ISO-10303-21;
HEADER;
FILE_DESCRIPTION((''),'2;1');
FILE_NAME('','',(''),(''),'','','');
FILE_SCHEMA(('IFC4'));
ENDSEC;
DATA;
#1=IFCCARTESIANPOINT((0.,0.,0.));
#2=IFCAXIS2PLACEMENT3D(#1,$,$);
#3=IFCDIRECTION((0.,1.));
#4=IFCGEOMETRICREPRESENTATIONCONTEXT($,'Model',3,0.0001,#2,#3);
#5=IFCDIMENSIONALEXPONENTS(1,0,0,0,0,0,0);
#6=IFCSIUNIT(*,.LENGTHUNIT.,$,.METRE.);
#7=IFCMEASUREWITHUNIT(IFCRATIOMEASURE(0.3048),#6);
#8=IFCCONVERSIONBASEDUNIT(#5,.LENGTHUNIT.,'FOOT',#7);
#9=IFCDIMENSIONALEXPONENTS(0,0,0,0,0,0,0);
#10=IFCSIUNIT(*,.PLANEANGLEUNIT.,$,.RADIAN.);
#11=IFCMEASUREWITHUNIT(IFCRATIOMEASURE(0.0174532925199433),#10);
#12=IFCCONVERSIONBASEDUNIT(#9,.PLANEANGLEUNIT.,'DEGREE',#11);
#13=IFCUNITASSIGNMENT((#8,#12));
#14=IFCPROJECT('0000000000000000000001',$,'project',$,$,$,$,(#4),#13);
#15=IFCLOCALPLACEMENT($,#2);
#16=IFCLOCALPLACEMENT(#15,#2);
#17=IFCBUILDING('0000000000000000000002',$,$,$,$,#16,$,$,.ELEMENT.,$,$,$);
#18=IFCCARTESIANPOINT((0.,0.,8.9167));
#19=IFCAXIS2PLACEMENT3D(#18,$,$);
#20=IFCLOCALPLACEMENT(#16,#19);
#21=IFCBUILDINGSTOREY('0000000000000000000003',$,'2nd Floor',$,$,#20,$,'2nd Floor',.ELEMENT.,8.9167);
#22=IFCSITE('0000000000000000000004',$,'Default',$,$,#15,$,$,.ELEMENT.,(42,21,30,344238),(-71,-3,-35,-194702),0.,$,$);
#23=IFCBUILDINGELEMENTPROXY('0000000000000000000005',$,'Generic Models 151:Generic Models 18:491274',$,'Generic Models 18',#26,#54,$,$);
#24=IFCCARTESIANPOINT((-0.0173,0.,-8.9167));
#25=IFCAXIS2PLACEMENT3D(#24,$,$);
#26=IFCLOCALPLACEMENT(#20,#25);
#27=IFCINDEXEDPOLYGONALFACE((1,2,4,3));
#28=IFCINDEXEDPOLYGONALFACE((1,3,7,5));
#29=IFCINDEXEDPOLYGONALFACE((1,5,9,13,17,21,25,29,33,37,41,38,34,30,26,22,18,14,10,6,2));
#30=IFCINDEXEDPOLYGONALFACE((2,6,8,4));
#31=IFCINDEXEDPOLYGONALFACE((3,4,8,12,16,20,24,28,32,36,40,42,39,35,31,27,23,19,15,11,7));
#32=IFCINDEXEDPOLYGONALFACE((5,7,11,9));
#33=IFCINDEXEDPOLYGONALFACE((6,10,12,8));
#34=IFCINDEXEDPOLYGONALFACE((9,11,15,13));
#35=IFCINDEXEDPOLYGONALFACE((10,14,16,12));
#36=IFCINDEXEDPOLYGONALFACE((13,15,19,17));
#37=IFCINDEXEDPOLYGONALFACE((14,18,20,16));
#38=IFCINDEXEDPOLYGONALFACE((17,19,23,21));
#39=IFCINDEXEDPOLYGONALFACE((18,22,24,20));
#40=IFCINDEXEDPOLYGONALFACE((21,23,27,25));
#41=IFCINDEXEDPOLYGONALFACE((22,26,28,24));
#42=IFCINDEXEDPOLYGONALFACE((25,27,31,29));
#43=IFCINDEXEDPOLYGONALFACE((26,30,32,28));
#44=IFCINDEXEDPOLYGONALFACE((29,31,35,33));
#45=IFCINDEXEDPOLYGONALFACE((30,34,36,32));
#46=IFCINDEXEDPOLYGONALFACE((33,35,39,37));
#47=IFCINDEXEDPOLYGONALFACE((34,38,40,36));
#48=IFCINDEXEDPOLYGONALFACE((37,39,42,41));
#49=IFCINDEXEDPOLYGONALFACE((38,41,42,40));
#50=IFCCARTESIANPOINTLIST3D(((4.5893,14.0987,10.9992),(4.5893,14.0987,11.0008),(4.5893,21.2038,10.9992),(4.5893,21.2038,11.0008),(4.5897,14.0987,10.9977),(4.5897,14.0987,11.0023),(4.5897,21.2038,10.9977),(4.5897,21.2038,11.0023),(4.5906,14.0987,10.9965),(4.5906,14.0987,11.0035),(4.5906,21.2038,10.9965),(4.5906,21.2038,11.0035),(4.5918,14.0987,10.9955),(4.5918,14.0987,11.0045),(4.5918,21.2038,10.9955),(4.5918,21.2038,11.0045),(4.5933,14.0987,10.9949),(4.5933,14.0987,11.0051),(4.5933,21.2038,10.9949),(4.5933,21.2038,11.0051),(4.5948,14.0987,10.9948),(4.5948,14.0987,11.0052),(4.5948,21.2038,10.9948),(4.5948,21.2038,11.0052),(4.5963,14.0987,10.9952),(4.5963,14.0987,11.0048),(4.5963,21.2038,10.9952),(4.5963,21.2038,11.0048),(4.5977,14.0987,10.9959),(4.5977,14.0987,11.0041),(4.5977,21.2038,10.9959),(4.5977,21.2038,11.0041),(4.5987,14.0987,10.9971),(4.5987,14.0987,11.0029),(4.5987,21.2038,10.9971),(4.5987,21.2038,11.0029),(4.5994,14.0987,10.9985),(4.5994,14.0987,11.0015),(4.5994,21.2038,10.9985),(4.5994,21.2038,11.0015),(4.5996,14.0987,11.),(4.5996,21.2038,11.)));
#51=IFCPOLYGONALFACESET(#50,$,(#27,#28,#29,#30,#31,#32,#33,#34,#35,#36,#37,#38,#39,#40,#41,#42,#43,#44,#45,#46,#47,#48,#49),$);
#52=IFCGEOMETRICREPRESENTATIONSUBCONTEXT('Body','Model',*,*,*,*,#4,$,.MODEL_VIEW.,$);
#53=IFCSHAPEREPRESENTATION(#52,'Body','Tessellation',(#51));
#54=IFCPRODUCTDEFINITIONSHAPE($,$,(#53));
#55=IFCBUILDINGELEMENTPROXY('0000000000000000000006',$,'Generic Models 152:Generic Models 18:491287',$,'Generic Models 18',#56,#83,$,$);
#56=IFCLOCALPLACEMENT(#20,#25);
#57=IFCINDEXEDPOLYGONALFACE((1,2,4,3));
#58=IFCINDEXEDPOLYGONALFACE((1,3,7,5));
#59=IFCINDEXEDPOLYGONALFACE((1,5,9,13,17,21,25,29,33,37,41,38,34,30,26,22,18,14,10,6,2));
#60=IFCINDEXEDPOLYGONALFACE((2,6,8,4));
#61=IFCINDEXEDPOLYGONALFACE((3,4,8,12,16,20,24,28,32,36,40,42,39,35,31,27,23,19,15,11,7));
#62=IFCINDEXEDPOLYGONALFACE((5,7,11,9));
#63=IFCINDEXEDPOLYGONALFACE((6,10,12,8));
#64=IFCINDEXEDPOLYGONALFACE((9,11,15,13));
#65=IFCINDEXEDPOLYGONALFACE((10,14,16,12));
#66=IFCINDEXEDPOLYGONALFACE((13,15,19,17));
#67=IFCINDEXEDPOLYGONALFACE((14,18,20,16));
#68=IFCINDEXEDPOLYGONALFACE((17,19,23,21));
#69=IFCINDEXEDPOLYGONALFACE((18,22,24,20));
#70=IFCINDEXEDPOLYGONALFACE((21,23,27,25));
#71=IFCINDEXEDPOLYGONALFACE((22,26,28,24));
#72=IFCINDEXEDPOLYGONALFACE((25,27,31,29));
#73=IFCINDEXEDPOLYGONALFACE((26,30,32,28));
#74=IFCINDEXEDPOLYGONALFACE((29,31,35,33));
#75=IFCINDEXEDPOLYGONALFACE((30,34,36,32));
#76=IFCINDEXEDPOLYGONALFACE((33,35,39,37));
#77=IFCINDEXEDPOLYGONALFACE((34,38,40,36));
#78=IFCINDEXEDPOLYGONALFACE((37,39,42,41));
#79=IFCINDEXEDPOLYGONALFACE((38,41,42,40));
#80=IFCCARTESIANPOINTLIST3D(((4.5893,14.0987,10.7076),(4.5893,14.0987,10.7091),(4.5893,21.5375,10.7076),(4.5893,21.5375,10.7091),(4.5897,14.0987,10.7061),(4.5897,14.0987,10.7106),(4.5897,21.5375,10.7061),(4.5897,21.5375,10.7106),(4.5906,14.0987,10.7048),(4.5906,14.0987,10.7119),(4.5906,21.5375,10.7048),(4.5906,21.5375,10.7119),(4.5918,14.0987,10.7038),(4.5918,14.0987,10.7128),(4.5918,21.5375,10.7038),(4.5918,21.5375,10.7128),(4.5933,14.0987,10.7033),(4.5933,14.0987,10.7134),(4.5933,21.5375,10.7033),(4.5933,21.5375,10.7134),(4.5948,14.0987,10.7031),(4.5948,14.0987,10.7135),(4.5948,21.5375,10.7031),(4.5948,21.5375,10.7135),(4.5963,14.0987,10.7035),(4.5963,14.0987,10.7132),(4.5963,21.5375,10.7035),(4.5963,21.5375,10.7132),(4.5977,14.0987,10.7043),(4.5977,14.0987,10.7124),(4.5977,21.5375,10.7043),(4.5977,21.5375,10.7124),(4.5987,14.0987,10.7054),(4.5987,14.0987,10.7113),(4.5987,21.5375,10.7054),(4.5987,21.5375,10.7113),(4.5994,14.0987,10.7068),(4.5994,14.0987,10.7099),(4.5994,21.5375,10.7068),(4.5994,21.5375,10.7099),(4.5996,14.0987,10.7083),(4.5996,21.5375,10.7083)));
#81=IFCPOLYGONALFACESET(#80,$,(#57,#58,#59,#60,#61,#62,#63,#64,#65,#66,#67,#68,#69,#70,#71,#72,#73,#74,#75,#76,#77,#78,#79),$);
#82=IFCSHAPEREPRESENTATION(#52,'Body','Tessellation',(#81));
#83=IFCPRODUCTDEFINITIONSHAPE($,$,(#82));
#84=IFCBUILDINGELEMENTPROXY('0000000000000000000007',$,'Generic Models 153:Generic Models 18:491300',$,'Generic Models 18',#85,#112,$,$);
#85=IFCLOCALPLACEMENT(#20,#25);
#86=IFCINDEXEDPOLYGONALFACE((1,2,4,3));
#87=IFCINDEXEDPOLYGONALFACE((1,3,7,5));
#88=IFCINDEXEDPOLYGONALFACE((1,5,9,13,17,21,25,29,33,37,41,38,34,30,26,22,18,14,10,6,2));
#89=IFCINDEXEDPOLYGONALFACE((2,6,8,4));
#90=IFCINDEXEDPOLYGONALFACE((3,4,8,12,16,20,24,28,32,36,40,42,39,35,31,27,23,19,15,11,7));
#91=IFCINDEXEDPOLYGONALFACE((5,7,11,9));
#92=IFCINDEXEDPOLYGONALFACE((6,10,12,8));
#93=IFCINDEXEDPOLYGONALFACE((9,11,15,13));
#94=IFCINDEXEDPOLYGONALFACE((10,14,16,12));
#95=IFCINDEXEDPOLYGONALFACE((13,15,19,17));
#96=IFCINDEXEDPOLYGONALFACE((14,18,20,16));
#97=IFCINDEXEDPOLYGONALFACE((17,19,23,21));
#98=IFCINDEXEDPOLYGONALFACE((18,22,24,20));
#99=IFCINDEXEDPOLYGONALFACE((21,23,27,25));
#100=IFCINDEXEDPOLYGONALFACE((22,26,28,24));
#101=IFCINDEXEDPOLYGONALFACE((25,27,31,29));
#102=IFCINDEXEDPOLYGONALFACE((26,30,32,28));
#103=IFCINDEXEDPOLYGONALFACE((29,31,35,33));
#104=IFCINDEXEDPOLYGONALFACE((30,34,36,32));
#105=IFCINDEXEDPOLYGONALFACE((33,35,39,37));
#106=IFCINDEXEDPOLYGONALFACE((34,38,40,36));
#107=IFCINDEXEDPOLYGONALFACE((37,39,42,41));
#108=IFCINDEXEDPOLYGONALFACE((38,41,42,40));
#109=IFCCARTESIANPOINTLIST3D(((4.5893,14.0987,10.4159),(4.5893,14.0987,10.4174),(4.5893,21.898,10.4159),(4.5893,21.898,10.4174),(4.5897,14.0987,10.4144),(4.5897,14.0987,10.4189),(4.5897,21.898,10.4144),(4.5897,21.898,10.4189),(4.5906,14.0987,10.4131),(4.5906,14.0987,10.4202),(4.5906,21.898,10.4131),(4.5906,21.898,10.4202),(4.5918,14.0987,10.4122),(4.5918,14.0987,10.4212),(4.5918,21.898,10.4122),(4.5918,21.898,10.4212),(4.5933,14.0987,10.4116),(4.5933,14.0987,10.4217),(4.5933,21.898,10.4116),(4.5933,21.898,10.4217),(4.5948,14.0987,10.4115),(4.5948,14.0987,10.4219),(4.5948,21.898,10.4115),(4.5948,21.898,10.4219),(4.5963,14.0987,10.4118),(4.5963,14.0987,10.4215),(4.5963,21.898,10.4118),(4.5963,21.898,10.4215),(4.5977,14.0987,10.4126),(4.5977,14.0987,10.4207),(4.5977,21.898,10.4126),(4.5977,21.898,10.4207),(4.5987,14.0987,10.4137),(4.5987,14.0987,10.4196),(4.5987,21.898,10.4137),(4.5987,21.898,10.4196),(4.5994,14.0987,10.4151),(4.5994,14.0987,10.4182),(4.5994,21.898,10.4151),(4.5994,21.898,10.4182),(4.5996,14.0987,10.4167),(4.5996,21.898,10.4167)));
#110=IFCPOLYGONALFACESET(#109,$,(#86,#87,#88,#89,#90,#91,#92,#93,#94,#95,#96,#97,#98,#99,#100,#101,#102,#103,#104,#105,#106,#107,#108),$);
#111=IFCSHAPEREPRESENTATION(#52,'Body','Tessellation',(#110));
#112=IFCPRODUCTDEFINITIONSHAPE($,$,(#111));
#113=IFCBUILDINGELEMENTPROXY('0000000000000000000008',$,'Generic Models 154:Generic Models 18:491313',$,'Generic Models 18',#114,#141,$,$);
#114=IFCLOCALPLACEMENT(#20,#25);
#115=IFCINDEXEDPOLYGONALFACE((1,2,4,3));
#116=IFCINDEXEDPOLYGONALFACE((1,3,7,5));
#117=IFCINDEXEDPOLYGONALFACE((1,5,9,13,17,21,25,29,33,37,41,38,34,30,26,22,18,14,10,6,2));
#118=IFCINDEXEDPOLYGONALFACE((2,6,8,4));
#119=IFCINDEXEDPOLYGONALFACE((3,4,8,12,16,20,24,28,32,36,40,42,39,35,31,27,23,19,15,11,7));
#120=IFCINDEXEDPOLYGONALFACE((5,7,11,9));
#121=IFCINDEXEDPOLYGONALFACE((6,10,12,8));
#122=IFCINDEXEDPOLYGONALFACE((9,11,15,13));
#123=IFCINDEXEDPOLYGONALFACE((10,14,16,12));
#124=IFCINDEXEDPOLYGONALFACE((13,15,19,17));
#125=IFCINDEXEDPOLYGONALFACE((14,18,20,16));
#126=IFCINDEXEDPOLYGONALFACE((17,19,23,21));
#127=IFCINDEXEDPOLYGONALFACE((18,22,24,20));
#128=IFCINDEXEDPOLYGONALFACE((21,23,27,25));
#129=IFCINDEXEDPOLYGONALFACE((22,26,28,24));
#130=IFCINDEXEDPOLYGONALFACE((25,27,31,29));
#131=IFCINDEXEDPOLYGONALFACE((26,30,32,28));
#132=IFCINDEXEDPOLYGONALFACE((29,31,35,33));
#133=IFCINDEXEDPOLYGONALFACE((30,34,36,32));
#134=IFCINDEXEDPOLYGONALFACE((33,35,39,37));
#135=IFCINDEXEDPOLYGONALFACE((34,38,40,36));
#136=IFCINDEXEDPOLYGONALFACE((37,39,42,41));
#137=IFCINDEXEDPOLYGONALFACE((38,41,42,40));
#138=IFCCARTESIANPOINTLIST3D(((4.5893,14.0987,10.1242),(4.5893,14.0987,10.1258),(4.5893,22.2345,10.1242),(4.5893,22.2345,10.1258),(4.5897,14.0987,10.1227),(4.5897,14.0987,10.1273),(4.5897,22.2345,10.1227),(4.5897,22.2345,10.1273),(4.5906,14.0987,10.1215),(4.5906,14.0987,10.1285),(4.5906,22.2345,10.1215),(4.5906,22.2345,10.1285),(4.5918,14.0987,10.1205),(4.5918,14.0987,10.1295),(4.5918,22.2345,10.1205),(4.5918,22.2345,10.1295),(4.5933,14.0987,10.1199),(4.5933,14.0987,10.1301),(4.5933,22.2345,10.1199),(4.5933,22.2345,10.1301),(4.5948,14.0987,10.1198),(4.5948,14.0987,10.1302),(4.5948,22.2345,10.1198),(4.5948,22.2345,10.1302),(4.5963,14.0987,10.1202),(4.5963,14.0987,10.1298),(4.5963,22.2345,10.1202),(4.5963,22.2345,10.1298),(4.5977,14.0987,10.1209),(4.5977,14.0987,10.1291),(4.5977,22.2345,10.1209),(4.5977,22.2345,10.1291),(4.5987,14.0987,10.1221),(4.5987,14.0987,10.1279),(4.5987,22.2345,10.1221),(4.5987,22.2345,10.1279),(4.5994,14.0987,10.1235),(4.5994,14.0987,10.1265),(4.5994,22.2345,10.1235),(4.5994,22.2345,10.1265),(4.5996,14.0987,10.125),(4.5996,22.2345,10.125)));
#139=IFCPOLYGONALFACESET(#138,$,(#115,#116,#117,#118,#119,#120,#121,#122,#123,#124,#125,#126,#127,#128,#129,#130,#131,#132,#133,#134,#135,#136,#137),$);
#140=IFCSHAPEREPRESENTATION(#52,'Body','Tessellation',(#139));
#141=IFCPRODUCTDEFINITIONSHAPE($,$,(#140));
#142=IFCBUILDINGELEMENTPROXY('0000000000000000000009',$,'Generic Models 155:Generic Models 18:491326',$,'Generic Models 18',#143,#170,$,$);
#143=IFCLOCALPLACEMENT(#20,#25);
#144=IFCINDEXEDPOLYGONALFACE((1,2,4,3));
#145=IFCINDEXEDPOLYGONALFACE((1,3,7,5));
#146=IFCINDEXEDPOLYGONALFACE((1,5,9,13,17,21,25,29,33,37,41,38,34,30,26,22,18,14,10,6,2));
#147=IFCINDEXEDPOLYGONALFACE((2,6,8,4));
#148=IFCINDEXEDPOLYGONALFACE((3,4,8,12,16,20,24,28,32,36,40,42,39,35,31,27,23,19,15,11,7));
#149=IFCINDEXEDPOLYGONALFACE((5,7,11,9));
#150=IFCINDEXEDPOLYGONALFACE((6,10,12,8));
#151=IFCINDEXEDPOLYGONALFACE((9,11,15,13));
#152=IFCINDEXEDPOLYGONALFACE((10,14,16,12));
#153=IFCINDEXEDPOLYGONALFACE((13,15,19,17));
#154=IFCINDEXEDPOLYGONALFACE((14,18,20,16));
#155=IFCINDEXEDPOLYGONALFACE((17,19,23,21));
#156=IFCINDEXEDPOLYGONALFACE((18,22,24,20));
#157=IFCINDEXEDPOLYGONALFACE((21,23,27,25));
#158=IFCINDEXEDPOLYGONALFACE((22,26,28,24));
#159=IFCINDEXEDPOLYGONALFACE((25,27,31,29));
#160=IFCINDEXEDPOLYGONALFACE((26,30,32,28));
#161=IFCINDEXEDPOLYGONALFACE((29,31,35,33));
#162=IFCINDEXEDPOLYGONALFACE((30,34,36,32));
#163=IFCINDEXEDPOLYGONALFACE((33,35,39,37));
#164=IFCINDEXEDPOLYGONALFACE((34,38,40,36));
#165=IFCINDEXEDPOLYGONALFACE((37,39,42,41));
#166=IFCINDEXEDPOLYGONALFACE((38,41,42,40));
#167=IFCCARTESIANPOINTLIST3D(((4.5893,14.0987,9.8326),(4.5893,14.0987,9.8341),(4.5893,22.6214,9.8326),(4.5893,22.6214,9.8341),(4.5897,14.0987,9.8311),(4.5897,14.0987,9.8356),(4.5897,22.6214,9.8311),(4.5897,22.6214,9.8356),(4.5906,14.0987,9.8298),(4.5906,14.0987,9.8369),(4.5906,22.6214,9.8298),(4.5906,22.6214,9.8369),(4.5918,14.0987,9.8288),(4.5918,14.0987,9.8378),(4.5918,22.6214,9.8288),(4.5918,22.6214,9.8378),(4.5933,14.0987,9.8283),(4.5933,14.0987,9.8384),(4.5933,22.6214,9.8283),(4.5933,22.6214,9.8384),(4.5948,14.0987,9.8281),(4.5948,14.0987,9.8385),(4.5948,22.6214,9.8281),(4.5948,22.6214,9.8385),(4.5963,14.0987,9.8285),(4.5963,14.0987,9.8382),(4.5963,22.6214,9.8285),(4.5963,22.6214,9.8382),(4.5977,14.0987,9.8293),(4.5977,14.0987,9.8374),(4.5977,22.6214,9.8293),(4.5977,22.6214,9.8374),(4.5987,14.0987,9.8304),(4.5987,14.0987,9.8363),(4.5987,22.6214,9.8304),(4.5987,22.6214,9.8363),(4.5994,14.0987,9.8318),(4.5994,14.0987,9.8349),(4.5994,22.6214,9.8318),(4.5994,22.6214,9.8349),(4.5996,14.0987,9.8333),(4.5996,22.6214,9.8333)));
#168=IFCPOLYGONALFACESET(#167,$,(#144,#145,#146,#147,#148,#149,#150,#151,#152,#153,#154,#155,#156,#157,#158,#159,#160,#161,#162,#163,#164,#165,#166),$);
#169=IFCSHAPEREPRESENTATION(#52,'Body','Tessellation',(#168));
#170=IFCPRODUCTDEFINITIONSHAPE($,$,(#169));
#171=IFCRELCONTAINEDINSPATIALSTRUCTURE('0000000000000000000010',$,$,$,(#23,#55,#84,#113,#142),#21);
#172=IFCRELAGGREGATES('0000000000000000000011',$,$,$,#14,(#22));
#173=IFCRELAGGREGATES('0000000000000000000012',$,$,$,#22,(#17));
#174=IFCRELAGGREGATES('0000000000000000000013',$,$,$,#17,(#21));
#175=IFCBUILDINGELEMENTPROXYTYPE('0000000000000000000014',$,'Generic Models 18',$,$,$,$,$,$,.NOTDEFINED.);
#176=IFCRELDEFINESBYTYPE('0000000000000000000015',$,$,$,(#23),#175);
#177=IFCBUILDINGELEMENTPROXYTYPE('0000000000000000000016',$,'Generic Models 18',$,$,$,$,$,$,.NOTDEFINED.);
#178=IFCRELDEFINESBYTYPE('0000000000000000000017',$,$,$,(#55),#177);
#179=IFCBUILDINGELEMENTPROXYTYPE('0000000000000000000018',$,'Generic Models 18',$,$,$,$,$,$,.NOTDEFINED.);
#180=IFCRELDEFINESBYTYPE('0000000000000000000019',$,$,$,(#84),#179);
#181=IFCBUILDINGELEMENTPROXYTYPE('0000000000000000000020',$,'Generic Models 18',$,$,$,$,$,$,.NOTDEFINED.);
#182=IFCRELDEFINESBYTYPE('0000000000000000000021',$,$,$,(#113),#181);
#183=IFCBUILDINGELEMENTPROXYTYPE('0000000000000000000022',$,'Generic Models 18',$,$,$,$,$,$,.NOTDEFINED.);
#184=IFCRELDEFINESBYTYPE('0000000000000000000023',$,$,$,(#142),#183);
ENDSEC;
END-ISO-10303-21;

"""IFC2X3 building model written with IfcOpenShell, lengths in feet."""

from ifc_helpers import new_model, entity, si_unit, converted_unit, direction, frame, origin, origin_2d_with_axis, place, context, subcontext, project, spatial, circle, extrude, source, transform, mapped, type_object, type_shapes, element, save


model = new_model("IFC2X3")

# Units and contexts
model_context = context("Model", 3, precision=0.0001, world=origin(), true_north=direction((0.0, 1.0)))
body_context = subcontext(model_context, "Body", "Model", "MODEL_VIEW")
ifc_project = project(units=[converted_unit("LENGTHUNIT", "FOOT", entity("IfcRatioMeasure", 0.3048), si_unit("LENGTHUNIT", "METRE"), dimensions=[1, 0, 0, 0, 0, 0, 0]), converted_unit("PLANEANGLEUNIT", "DEGREE", entity("IfcRatioMeasure", 0.0174532925199433), si_unit("PLANEANGLEUNIT", "RADIAN"), dimensions=[0, 0, 0, 0, 0, 0, 0])], contexts=[model_context])

# Site, building, storey
site_placement = place(None, origin())
site = spatial("IfcSite", under=ifc_project, at=site_placement, Name="Default", CompositionType="ELEMENT", RefLatitude=(42, 21, 30, 344238), RefLongitude=(-71, -3, -35, -194702), RefElevation=0.0)
building_placement = place(site_placement, origin())
building = spatial("IfcBuilding", under=site, at=building_placement, CompositionType="ELEMENT")
storey_placement = place(building_placement, frame((0.0, 0.0, 8.9167)))
storey = spatial("IfcBuildingStorey", under=building, at=storey_placement, Name="2nd Floor", LongName="2nd Floor", CompositionType="ELEMENT", Elevation=8.9167)

# Building element proxies
building_element_proxy_type_1 = type_object("IfcBuildingElementProxyType", Name="Generic Models 18", PredefinedType="NOTDEFINED")
shared_shape_1 = source(origin(), body_context, "Body", "SweptSolid", [
    extrude(circle(Radius=0.0052, at=origin_2d_with_axis()), frame((4.5944, 14.0987, 11.0), z_axis=(0.0, 1.0, 0.0), x_axis=(1.0, 0.0, 0.0)), (0.0, 0.0, 1.0), 7.105),
])
type_shapes(building_element_proxy_type_1, [shared_shape_1])
proxy_1_placement = place(storey_placement, frame((-0.0173, 0.0, -8.9167)))
element("IfcBuildingElementProxy", 1, at=proxy_1_placement, inside=storey, type_object=building_element_proxy_type_1, Name="Generic Models 151:Generic Models 18:491274", ObjectType="Generic Models 18", context=body_context, shape_type="MappedRepresentation", body=[
    mapped(shared_shape_1, transform((0.0, 0.0, 0.0), scale=1.0)),
])
building_element_proxy_type_2 = type_object("IfcBuildingElementProxyType", Name="Generic Models 18", PredefinedType="NOTDEFINED")
shared_shape_2 = source(origin(), body_context, "Body", "SweptSolid", [
    extrude(circle(Radius=0.0052, at=origin_2d_with_axis()), frame((4.5944, 14.0987, 10.7083), z_axis=(0.0, 1.0, 0.0), x_axis=(1.0, 0.0, 0.0)), (0.0, 0.0, 1.0), 7.4388),
])
type_shapes(building_element_proxy_type_2, [shared_shape_2])
proxy_2_placement = place(storey_placement, frame((-0.0173, 0.0, -8.9167)))
element("IfcBuildingElementProxy", 2, at=proxy_2_placement, inside=storey, type_object=building_element_proxy_type_2, Name="Generic Models 152:Generic Models 18:491287", ObjectType="Generic Models 18", context=body_context, shape_type="MappedRepresentation", body=[
    mapped(shared_shape_2, transform((0.0, 0.0, 0.0), scale=1.0)),
])
building_element_proxy_type_3 = type_object("IfcBuildingElementProxyType", Name="Generic Models 18", PredefinedType="NOTDEFINED")
shared_shape_3 = source(origin(), body_context, "Body", "SweptSolid", [
    extrude(circle(Radius=0.0052, at=origin_2d_with_axis()), frame((4.5944, 14.0987, 10.4167), z_axis=(0.0, 1.0, 0.0), x_axis=(1.0, 0.0, 0.0)), (0.0, 0.0, 1.0), 7.7993),
])
type_shapes(building_element_proxy_type_3, [shared_shape_3])
proxy_3_placement = place(storey_placement, frame((-0.0173, 0.0, -8.9167)))
element("IfcBuildingElementProxy", 3, at=proxy_3_placement, inside=storey, type_object=building_element_proxy_type_3, Name="Generic Models 153:Generic Models 18:491300", ObjectType="Generic Models 18", context=body_context, shape_type="MappedRepresentation", body=[
    mapped(shared_shape_3, transform((0.0, 0.0, 0.0), scale=1.0)),
])
building_element_proxy_type_4 = type_object("IfcBuildingElementProxyType", Name="Generic Models 18", PredefinedType="NOTDEFINED")
shared_shape_4 = source(origin(), body_context, "Body", "SweptSolid", [
    extrude(circle(Radius=0.0052, at=origin_2d_with_axis()), frame((4.5944, 14.0987, 10.125), z_axis=(0.0, 1.0, 0.0), x_axis=(1.0, 0.0, 0.0)), (0.0, 0.0, 1.0), 8.1358),
])
type_shapes(building_element_proxy_type_4, [shared_shape_4])
proxy_4_placement = place(storey_placement, frame((-0.0173, 0.0, -8.9167)))
element("IfcBuildingElementProxy", 4, at=proxy_4_placement, inside=storey, type_object=building_element_proxy_type_4, Name="Generic Models 154:Generic Models 18:491313", ObjectType="Generic Models 18", context=body_context, shape_type="MappedRepresentation", body=[
    mapped(shared_shape_4, transform((0.0, 0.0, 0.0), scale=1.0)),
])
building_element_proxy_type_5 = type_object("IfcBuildingElementProxyType", Name="Generic Models 18", PredefinedType="NOTDEFINED")
shared_shape_5 = source(origin(), body_context, "Body", "SweptSolid", [
    extrude(circle(Radius=0.0052, at=origin_2d_with_axis()), frame((4.5944, 14.0987, 9.8333), z_axis=(0.0, 1.0, 0.0), x_axis=(1.0, 0.0, 0.0)), (0.0, 0.0, 1.0), 8.5227),
])
type_shapes(building_element_proxy_type_5, [shared_shape_5])
proxy_5_placement = place(storey_placement, frame((-0.0173, 0.0, -8.9167)))
element("IfcBuildingElementProxy", 5, at=proxy_5_placement, inside=storey, type_object=building_element_proxy_type_5, Name="Generic Models 155:Generic Models 18:491326", ObjectType="Generic Models 18", context=body_context, shape_type="MappedRepresentation", body=[
    mapped(shared_shape_5, transform((0.0, 0.0, 0.0), scale=1.0)),
])

save(model, "model.ifc")
